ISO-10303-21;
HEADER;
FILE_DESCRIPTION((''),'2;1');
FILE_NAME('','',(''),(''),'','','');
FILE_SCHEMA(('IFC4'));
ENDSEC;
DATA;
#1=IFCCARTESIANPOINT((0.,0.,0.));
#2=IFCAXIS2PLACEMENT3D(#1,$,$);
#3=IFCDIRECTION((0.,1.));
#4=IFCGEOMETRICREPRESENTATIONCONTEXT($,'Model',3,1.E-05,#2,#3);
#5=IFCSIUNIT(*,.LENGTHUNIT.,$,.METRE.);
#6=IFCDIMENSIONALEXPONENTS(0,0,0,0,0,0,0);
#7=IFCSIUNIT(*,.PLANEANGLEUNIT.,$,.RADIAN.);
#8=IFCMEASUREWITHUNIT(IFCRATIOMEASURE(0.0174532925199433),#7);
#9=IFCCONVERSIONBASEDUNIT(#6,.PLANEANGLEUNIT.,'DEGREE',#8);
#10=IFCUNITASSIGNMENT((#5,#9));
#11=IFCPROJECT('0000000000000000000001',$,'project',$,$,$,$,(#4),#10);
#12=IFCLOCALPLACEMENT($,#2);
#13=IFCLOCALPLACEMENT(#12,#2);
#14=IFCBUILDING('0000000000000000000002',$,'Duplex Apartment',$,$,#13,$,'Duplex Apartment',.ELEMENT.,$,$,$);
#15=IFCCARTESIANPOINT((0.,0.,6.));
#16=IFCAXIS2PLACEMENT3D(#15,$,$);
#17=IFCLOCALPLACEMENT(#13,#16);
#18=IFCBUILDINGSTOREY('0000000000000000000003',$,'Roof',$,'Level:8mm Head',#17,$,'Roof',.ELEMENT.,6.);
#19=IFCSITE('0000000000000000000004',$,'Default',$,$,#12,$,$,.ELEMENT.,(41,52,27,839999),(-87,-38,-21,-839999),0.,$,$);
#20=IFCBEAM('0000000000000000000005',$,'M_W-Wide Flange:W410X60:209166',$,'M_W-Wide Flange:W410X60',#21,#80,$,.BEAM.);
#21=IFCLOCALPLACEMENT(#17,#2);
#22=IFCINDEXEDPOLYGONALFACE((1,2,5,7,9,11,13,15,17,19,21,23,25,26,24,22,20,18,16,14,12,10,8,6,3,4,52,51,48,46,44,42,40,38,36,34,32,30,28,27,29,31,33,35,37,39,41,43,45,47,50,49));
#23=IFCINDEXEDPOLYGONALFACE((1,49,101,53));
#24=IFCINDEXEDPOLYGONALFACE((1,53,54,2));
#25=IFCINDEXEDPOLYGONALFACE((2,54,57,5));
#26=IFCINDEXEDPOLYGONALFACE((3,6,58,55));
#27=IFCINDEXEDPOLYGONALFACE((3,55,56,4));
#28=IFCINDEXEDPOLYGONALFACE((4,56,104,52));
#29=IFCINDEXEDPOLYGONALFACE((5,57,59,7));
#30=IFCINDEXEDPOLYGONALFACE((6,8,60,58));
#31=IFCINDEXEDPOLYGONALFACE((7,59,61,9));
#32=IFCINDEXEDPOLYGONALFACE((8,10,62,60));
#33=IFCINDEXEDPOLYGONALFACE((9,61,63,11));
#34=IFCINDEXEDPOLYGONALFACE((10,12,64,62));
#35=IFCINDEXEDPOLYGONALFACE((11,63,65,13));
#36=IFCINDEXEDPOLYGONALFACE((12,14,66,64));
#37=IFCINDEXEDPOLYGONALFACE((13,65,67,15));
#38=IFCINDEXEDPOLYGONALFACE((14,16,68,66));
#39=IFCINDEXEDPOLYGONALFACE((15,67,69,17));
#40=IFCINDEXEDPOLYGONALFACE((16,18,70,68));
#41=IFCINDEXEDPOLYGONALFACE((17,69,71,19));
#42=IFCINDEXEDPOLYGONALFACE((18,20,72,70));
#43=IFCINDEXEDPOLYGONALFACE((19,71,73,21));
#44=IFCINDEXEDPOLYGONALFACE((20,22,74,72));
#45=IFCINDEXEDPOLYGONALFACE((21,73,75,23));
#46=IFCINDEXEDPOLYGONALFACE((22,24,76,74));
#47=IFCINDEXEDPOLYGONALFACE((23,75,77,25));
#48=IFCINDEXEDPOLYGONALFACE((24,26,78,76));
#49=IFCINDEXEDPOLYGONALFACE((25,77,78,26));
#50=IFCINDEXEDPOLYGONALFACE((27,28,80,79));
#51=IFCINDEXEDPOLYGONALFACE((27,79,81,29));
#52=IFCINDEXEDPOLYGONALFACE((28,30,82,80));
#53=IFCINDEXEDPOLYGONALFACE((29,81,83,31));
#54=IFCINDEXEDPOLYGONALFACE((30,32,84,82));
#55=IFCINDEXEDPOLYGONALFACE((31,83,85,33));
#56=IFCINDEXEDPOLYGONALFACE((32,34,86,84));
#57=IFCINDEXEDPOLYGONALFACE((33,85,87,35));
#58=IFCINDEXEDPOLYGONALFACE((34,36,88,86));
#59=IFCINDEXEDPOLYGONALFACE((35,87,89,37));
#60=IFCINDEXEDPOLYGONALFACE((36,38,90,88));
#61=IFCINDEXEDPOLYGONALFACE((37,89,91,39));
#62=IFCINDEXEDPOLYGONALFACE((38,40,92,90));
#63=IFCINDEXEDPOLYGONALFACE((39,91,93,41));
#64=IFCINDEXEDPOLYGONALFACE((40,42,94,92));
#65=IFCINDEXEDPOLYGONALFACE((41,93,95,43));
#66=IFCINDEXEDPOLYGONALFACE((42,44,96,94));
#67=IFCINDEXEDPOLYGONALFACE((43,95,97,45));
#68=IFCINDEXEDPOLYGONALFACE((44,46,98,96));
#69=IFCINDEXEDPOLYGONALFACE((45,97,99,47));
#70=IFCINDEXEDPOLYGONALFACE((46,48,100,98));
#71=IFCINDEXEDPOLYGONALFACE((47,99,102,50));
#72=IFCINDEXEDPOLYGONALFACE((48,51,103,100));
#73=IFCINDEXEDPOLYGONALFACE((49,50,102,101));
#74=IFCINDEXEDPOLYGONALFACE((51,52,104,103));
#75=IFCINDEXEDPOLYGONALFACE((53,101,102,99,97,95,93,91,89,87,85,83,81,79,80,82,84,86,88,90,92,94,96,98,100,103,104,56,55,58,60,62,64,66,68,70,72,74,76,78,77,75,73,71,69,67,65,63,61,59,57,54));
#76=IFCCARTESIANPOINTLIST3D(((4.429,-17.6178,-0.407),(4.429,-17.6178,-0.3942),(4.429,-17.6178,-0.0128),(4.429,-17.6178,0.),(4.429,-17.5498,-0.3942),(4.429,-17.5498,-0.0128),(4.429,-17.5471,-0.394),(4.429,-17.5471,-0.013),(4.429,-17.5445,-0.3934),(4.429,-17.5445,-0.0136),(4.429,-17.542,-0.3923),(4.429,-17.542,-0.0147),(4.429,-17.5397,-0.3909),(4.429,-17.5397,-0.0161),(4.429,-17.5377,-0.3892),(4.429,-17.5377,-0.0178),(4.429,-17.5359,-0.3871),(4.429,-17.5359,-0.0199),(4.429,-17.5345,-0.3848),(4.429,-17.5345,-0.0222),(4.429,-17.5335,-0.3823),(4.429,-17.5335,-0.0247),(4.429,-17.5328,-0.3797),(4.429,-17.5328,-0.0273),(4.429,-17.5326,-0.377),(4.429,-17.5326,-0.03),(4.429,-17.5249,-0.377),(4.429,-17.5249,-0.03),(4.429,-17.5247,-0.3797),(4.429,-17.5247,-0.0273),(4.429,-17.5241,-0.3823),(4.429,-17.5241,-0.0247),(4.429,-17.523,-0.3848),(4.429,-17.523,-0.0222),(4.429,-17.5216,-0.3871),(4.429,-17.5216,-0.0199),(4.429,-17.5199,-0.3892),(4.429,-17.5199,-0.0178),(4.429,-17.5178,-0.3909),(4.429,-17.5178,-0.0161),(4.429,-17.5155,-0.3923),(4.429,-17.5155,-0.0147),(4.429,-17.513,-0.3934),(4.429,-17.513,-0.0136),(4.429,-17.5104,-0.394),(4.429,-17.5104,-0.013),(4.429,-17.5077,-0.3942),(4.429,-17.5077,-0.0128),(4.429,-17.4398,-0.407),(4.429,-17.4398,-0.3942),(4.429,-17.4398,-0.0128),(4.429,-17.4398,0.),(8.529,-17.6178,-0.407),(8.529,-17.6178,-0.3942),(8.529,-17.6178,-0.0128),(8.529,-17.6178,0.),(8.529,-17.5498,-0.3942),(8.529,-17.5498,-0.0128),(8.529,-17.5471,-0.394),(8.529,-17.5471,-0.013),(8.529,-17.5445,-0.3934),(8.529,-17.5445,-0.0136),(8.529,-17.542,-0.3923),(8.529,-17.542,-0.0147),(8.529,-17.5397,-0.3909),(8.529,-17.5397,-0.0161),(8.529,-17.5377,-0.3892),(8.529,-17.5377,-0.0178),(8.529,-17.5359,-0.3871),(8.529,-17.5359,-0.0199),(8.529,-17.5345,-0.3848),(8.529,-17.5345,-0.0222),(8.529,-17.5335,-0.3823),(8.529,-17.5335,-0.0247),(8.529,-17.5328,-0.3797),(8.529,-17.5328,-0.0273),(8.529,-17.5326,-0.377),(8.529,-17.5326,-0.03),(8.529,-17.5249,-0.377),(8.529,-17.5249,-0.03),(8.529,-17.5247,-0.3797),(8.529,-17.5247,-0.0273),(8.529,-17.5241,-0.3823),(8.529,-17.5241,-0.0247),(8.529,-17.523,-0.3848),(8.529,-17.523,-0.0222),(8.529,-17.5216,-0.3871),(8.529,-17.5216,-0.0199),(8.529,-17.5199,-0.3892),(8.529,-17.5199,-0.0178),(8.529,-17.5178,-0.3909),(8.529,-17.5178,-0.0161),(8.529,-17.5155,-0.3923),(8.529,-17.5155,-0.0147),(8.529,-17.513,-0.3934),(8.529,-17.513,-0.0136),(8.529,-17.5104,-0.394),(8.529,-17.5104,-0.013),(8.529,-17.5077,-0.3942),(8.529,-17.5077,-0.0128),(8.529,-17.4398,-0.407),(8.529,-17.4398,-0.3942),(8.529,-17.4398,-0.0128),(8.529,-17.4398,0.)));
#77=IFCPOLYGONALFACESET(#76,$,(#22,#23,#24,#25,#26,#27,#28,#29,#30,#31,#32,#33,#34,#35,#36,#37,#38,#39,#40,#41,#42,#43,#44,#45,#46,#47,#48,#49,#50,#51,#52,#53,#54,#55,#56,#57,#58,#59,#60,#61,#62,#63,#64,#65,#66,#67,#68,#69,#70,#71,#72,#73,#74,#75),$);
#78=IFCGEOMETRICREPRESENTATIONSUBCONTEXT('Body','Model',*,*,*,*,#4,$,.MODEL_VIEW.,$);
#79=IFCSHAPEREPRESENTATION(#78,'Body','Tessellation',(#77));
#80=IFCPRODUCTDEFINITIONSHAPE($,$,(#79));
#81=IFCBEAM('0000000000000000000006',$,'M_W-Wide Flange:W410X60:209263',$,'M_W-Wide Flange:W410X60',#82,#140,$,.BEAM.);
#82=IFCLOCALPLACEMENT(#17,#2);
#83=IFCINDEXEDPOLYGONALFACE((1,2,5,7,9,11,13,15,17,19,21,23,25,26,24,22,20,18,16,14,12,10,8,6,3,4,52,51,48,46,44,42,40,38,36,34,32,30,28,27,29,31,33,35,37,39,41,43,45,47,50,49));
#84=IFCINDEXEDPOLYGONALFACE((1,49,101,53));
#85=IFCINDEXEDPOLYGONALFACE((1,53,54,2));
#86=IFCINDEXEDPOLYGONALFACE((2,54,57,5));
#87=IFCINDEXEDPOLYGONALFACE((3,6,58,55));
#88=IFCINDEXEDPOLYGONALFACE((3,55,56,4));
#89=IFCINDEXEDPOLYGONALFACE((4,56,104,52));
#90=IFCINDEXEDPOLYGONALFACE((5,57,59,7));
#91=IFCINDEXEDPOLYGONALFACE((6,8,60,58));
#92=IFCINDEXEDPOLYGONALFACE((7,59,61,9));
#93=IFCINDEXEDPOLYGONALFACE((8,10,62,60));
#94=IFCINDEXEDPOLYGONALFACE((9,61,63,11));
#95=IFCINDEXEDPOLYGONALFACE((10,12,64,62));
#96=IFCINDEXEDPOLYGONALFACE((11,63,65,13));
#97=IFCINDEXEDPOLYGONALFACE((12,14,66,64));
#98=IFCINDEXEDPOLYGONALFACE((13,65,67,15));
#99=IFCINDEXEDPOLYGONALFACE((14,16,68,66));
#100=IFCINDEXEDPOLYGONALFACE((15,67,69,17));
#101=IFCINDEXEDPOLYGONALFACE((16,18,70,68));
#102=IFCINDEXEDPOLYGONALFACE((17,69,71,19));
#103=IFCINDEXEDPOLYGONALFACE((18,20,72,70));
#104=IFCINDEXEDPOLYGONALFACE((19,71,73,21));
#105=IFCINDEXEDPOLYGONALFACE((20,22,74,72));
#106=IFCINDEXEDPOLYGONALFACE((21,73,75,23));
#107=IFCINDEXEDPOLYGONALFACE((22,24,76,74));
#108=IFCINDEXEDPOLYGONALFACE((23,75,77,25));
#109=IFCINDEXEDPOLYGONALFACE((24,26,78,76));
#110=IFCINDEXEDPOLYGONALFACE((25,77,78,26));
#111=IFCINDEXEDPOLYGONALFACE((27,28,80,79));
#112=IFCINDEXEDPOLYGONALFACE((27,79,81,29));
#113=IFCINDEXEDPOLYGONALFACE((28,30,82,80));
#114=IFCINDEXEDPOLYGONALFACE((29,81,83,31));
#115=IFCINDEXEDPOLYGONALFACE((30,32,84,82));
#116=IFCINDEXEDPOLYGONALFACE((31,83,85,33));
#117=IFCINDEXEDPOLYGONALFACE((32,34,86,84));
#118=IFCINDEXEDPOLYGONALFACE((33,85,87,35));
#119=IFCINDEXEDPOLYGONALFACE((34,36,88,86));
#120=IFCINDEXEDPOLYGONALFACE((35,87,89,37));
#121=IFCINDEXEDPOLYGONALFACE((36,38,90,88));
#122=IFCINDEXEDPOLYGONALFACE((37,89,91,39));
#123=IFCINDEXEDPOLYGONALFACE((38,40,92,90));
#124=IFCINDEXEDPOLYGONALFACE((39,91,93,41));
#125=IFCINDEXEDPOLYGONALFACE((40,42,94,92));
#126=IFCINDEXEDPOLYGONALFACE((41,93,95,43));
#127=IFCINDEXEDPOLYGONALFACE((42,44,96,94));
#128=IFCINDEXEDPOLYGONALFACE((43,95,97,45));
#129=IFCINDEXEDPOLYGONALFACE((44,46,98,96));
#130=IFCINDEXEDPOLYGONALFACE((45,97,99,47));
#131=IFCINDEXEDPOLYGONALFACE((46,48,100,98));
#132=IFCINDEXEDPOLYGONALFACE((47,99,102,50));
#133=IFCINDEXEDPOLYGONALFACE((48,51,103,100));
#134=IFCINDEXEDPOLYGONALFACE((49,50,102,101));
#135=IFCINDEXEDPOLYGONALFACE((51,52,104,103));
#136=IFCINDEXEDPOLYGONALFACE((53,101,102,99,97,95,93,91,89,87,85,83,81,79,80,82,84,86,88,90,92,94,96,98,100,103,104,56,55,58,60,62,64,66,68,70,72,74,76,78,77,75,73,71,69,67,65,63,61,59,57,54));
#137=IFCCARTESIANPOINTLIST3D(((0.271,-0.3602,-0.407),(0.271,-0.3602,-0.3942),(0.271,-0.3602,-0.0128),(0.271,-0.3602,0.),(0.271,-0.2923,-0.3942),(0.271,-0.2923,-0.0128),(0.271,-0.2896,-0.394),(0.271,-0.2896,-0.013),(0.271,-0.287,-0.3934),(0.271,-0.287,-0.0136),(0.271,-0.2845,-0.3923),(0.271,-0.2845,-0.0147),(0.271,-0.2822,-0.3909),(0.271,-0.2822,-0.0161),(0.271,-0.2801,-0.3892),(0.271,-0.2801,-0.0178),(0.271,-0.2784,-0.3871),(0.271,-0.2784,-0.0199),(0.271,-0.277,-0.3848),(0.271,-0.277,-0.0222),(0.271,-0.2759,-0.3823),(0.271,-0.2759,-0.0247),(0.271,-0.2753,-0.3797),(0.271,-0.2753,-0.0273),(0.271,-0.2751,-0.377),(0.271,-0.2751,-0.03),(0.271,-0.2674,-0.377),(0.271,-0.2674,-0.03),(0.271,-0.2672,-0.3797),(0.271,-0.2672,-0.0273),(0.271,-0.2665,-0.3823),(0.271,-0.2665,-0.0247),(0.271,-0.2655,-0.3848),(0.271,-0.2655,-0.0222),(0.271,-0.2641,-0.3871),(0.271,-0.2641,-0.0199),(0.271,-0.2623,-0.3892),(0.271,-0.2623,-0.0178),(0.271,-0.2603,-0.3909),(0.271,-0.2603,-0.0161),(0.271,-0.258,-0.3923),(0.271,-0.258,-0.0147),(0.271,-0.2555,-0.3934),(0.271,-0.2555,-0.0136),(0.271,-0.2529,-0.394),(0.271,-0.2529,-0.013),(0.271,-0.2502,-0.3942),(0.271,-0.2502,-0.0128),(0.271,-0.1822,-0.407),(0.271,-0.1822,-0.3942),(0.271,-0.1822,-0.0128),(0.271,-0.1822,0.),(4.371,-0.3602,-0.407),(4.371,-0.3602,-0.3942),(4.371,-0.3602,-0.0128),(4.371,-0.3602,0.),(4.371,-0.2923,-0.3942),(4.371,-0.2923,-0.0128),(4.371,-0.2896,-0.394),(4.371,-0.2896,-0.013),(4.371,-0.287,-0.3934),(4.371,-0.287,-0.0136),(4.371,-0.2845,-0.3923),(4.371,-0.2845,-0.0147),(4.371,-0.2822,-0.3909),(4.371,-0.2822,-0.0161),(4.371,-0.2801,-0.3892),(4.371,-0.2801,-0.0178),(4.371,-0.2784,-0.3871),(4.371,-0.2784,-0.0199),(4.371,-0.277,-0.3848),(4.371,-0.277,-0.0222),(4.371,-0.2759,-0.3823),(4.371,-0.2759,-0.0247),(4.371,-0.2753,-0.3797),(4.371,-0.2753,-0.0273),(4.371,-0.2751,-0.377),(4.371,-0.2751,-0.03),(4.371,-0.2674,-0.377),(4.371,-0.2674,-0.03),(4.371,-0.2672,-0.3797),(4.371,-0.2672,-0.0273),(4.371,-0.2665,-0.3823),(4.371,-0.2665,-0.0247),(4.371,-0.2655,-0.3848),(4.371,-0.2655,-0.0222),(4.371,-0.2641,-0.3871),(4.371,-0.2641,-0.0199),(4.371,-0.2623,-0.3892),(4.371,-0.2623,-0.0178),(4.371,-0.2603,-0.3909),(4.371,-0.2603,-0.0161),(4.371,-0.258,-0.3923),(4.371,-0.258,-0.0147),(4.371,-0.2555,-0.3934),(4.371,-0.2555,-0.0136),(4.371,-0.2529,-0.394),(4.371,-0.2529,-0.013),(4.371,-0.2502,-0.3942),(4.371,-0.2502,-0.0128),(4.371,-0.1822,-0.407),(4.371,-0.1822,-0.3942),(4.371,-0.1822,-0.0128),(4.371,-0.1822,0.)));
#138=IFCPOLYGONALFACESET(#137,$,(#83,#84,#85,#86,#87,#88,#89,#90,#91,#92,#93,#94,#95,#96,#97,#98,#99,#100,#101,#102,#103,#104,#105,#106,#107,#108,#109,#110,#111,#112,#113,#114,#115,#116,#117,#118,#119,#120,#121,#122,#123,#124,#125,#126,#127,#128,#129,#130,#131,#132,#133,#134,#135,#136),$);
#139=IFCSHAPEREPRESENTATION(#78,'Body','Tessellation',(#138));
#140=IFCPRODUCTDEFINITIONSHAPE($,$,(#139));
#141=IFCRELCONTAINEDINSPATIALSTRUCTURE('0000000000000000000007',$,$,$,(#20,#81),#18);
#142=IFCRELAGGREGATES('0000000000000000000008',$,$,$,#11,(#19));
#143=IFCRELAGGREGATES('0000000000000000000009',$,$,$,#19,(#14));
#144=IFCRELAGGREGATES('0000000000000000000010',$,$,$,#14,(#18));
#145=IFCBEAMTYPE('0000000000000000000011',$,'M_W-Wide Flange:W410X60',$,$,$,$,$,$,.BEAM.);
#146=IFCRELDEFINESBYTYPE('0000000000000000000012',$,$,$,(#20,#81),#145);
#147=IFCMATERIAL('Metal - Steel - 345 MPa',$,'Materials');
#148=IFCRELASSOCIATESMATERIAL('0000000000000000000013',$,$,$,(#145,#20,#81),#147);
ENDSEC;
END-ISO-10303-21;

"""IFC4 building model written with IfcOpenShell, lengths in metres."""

from ifc_helpers import new_model, entity, si_unit, converted_unit, direction, frame, origin, place, context, subcontext, project, spatial, indexed_curve, outline, extrude, source, transform, mapped, material, type_object, type_shapes, element, save


model = new_model("IFC4")

# Units and contexts
model_context = context("Model", 3, precision=1e-05, world=origin(), true_north=direction((0.0, 1.0)))
body_context = subcontext(model_context, "Body", "Model", "MODEL_VIEW")
ifc_project = project(units=[si_unit("LENGTHUNIT", "METRE"), converted_unit("PLANEANGLEUNIT", "DEGREE", entity("IfcRatioMeasure", 0.0174532925199433), si_unit("PLANEANGLEUNIT", "RADIAN"), dimensions=[0, 0, 0, 0, 0, 0, 0])], contexts=[model_context])

# Site, building, storey
site_placement = place(None, origin())
site = spatial("IfcSite", under=ifc_project, at=site_placement, Name="Default", CompositionType="ELEMENT", RefLatitude=(41, 52, 27, 839999), RefLongitude=(-87, -38, -21, -839999), RefElevation=0.0)
building_placement = place(site_placement, origin())
building = spatial("IfcBuilding", under=site, at=building_placement, Name="Duplex Apartment", LongName="Duplex Apartment", CompositionType="ELEMENT")
storey_placement = place(building_placement, frame((0.0, 0.0, 6.0)))
storey = spatial("IfcBuildingStorey", under=building, at=storey_placement, Name="Roof", ObjectType="Level:8mm Head", LongName="Roof", CompositionType="ELEMENT", Elevation=6.0)

# Beams
ifc_material_1 = material(Name="Metal - Steel - 345 MPa", Category="Materials")
beam_type_1 = type_object("IfcBeamType", Name="M_W-Wide Flange:W410X60", PredefinedType="BEAM", material=ifc_material_1)
shared_shape_1 = source(origin(), body_context, "Body", "SweptSolid", [
    extrude(outline(indexed_curve([(-0.2035, -0.089), (-0.1907, -0.089), (-0.1907, -0.021), (-0.1905, -0.0184), (-0.1899, -0.0157), (-0.1888, -0.0132), (-0.1874, -0.0109), (-0.1857, -0.0089), (-0.1836, -0.0071), (-0.1813, -0.0057), (-0.1788, -0.0047), (-0.1762, -0.0041), (-0.1735, -0.0038), (0.1735, -0.0038), (0.1762, -0.0041), (0.1788, -0.0047), (0.1813, -0.0057), (0.1836, -0.0071), (0.1857, -0.0089), (0.1874, -0.0109), (0.1888, -0.0132), (0.1899, -0.0157), (0.1905, -0.0184), (0.1907, -0.021), (0.1907, -0.089), (0.2035, -0.089), (0.2035, 0.089), (0.1907, 0.089), (0.1907, 0.0211), (0.1905, 0.0184), (0.1899, 0.0157), (0.1888, 0.0132), (0.1874, 0.0109), (0.1857, 0.0089), (0.1836, 0.0071), (0.1813, 0.0057), (0.1788, 0.0047), (0.1762, 0.0041), (0.1735, 0.0039), (-0.1735, 0.0039), (-0.1762, 0.0041), (-0.1788, 0.0047), (-0.1813, 0.0057), (-0.1836, 0.0071), (-0.1857, 0.0089), (-0.1874, 0.0109), (-0.1888, 0.0132), (-0.1899, 0.0157), (-0.1905, 0.0184), (-0.1907, 0.0211), (-0.1907, 0.089), (-0.2035, 0.089), (-0.2035, -0.089)], self_intersect=False)), frame((-2.05, 0.0, 0.0), z_axis=(1.0, 0.0, 0.0), x_axis=(0.0, 0.0, -1.0)), (0.0, 0.0, 1.0), 4.1),
])
type_shapes(beam_type_1, [shared_shape_1])
beam_1_placement = place(storey_placement, frame((6.479, -17.5288, -0.2035)))
element("IfcBeam", 1, at=beam_1_placement, inside=storey, type_object=beam_type_1, material=ifc_material_1, Name="M_W-Wide Flange:W410X60:209166", ObjectType="M_W-Wide Flange:W410X60", PredefinedType="BEAM", context=body_context, shape_type="MappedRepresentation", body=[
    mapped(shared_shape_1, transform((0.0, 0.0, 0.0), scale=1.0)),
])
beam_2_placement = place(storey_placement, frame((2.321, -0.2712, -0.2035), z_axis=(0.0, 0.0, 1.0), x_axis=(-1.0, 0.0, 0.0)))
element("IfcBeam", 2, at=beam_2_placement, inside=storey, type_object=beam_type_1, material=ifc_material_1, Name="M_W-Wide Flange:W410X60:209263", ObjectType="M_W-Wide Flange:W410X60", PredefinedType="BEAM", context=body_context, shape_type="MappedRepresentation", body=[
    mapped(shared_shape_1, transform((0.0, 0.0, 0.0), scale=1.0)),
])

save(model, "model.ifc")
